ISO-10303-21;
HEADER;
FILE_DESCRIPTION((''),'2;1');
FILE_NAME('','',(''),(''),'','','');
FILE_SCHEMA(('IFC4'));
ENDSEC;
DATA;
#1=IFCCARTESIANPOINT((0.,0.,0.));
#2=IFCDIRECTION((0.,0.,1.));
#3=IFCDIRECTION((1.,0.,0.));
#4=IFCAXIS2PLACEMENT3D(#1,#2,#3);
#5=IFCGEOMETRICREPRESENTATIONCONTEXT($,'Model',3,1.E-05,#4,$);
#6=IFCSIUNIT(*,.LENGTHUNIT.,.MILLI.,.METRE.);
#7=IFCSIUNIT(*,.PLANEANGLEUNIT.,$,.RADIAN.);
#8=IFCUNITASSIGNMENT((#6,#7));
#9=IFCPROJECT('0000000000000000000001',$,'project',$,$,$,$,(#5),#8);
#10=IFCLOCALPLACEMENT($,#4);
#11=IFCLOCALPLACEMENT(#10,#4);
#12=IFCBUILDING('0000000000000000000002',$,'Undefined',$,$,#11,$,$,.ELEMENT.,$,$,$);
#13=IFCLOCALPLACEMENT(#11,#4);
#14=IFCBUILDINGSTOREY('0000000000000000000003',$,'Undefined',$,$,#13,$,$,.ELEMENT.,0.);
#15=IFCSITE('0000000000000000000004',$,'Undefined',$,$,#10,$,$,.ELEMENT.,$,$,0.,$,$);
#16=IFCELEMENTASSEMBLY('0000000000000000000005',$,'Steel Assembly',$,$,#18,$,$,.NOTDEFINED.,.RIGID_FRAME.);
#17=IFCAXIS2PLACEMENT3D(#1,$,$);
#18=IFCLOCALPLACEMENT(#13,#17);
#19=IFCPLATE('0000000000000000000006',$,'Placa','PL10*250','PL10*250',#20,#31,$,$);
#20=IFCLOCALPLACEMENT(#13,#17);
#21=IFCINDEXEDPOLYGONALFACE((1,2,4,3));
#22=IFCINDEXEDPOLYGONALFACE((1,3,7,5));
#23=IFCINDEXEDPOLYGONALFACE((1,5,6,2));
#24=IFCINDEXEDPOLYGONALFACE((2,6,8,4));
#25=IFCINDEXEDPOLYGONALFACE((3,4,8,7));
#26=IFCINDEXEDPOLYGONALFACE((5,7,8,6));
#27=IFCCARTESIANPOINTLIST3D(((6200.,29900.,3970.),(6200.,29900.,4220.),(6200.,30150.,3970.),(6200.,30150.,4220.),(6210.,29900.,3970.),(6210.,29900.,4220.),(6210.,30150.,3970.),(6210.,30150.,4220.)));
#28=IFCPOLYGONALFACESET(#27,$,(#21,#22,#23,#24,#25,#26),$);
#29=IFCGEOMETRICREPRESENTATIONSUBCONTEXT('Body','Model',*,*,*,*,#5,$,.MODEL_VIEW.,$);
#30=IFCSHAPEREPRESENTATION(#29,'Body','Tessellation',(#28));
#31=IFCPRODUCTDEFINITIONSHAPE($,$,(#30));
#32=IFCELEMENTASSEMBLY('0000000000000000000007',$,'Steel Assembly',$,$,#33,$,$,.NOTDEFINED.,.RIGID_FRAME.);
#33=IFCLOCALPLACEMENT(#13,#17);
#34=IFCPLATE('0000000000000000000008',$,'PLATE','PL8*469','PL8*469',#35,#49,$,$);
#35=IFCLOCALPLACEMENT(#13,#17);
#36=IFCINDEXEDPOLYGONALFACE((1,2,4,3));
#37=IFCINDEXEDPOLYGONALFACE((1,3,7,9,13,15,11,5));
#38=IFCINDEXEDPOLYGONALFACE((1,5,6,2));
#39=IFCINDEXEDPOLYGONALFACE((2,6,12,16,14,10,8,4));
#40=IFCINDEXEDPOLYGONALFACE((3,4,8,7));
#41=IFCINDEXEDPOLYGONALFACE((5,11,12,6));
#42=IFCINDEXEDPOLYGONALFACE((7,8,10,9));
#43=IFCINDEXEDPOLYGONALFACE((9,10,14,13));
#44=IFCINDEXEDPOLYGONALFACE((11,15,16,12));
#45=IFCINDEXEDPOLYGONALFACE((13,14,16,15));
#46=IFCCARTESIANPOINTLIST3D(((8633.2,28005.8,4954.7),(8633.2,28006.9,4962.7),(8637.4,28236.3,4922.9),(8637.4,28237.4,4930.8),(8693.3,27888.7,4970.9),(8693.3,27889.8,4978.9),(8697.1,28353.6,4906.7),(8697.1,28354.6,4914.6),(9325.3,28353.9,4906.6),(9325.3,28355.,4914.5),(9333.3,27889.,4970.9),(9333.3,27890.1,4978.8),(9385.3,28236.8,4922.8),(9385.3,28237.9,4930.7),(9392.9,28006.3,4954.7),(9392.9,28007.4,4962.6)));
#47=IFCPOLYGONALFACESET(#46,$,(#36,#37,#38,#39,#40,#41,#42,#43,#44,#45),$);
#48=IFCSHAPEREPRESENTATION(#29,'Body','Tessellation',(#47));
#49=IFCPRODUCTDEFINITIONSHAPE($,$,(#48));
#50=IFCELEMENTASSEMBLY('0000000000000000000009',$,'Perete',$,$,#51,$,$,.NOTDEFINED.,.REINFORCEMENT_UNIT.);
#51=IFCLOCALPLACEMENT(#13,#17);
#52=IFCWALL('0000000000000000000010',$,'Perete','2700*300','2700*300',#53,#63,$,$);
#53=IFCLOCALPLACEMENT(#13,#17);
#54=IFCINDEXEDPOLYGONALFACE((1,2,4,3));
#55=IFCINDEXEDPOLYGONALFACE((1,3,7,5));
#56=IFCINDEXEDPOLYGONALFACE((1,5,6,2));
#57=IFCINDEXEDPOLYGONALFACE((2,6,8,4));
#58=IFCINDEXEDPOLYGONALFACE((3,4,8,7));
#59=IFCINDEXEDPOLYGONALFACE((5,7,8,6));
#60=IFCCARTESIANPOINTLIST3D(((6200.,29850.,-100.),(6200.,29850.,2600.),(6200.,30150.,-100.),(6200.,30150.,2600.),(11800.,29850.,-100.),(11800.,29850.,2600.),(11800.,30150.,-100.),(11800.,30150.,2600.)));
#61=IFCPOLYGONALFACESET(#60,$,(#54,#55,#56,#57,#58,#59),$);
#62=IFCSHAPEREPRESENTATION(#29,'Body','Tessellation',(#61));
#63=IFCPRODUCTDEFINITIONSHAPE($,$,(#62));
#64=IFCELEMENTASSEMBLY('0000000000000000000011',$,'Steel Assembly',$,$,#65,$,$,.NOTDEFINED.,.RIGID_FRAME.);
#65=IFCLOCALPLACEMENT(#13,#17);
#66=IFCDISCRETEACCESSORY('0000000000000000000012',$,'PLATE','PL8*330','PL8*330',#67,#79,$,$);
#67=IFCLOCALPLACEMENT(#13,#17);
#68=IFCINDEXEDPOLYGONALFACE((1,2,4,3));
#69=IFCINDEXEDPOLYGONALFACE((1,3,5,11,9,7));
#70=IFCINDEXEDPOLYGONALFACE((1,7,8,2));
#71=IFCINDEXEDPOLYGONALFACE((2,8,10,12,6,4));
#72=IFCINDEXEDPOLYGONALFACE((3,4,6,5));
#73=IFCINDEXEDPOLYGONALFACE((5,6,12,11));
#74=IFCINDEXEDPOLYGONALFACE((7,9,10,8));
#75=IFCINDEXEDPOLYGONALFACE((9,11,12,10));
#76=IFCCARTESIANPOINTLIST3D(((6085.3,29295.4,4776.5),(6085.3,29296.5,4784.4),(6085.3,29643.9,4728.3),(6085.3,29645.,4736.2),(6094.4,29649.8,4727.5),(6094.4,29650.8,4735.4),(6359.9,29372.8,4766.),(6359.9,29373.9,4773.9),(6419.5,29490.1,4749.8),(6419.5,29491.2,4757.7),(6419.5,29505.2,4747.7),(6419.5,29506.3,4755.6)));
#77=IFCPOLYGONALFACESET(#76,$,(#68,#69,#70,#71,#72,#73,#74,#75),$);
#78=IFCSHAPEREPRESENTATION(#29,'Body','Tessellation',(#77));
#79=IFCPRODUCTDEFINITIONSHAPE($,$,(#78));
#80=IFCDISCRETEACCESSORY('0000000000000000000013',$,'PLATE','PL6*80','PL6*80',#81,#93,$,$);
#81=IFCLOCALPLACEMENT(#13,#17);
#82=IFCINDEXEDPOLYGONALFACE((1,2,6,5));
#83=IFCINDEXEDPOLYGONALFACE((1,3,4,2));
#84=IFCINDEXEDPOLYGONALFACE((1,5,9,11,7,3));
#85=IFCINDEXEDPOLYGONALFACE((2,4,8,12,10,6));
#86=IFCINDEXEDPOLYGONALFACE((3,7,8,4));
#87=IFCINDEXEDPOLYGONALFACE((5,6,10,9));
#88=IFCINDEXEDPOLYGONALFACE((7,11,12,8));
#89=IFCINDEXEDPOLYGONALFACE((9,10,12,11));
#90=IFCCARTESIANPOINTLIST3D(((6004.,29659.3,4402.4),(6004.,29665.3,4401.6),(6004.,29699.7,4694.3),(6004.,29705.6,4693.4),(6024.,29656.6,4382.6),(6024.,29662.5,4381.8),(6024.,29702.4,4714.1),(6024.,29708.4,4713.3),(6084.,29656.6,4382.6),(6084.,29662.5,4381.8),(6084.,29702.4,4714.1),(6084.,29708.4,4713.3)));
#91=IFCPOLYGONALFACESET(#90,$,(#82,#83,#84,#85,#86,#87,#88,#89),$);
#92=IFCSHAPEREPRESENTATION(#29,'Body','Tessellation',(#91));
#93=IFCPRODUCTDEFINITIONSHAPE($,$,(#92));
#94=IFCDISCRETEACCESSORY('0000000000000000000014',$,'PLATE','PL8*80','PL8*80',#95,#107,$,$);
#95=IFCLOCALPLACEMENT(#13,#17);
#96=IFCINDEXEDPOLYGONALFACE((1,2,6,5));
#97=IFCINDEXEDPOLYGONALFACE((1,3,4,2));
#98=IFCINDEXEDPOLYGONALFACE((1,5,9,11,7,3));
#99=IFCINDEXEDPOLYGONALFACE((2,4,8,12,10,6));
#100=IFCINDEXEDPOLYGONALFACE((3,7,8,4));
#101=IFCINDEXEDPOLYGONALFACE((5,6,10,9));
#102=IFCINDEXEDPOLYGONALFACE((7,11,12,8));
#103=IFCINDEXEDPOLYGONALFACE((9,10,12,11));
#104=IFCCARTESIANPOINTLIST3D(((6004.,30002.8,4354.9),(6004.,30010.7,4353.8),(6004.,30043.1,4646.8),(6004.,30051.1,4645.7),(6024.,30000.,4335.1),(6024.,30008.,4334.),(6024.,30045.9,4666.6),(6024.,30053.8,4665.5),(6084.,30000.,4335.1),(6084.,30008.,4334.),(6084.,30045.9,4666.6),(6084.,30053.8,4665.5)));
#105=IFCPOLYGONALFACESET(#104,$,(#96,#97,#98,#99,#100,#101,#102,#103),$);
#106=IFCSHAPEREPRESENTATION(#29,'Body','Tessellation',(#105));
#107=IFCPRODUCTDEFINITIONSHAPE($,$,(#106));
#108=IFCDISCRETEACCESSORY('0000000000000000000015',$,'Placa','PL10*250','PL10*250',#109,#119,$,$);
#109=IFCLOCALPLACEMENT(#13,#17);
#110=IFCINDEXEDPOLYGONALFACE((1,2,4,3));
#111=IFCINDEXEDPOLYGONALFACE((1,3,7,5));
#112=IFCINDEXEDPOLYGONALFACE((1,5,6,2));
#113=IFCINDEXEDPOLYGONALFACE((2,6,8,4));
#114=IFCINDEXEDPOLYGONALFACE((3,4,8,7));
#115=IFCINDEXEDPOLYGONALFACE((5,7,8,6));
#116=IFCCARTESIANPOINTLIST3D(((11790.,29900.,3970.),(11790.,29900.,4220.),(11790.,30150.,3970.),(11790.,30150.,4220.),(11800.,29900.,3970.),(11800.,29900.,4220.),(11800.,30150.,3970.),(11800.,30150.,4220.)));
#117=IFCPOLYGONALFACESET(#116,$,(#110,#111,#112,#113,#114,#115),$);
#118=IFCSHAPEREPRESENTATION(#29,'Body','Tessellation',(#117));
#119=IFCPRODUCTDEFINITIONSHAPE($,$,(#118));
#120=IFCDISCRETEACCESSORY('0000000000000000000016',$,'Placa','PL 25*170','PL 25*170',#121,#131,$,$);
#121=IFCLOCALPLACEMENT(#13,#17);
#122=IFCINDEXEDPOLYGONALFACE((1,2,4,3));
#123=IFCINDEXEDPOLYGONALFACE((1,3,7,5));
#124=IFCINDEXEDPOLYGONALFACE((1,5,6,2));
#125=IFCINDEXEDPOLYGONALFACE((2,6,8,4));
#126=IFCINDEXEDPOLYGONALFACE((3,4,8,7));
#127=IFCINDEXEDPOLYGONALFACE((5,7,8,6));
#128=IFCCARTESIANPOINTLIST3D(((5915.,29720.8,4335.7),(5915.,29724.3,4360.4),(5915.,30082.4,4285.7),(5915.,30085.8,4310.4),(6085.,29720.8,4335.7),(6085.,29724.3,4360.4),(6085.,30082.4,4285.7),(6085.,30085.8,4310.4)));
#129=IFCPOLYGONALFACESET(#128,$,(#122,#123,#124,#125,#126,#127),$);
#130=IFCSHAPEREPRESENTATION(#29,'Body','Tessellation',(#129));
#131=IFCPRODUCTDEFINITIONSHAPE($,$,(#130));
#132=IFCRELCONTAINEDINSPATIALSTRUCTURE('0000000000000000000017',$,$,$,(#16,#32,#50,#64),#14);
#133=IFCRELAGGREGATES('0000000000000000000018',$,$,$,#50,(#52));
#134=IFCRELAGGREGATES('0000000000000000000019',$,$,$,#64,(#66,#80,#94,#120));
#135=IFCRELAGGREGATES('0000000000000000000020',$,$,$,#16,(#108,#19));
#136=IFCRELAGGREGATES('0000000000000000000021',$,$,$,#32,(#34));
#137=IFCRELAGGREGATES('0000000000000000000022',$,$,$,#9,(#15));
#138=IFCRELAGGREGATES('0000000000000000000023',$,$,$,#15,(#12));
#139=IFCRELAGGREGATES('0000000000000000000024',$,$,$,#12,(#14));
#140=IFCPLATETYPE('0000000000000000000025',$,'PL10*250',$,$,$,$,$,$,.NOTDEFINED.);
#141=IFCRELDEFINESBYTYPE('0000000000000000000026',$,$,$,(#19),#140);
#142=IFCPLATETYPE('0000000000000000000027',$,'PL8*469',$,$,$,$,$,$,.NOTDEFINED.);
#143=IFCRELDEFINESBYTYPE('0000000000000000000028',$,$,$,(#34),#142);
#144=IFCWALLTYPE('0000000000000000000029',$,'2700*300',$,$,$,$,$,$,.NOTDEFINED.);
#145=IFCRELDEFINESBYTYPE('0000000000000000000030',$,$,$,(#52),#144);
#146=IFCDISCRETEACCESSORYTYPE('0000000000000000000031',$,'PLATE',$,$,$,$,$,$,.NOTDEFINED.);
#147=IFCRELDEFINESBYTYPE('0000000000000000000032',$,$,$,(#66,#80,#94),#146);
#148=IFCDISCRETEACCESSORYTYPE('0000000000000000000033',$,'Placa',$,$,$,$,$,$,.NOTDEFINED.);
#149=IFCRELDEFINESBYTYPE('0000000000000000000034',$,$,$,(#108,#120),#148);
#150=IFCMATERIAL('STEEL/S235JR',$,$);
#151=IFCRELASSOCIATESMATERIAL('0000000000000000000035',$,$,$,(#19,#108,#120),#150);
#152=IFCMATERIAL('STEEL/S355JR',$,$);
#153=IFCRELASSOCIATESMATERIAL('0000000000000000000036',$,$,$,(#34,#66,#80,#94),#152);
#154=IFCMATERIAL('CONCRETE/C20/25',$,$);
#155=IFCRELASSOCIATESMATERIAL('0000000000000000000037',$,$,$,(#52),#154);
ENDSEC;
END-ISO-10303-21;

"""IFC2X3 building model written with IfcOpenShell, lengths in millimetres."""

from ifc_helpers import new_model, si_unit, frame, frame_2d, origin_with_axes, place, context, subcontext, project, spatial, polyline, rectangle, outline, extrude, material, type_object, element, aggregate, save


model = new_model("IFC2X3")

# Units and contexts
model_context = context("Model", 3, precision=1e-05, world=origin_with_axes())
body_context = subcontext(model_context, "Body", "Model", "MODEL_VIEW")
ifc_project = project(units=[si_unit("LENGTHUNIT", "METRE", prefix="MILLI"), si_unit("PLANEANGLEUNIT", "RADIAN")], contexts=[model_context])

# Site, building, storey
site_placement = place(None, origin_with_axes())
site = spatial("IfcSite", under=ifc_project, at=site_placement, Name="Undefined", CompositionType="ELEMENT", RefElevation=0.0)
building_placement = place(site_placement, origin_with_axes())
building = spatial("IfcBuilding", under=site, at=building_placement, Name="Undefined", CompositionType="ELEMENT")
storey_placement = place(building_placement, origin_with_axes())
storey = spatial("IfcBuildingStorey", under=building, at=storey_placement, Name="Undefined", CompositionType="ELEMENT", Elevation=0.0)

# Shared definitions
ifc_material_1 = material(Name="STEEL/S355JR")

# Element assemblies, plates
assembly_1_placement = place(storey_placement, origin_with_axes())
assembly_1 = element("IfcElementAssembly", 1, at=assembly_1_placement, inside=storey, Name="Steel Assembly", AssemblyPlace="NOTDEFINED", PredefinedType="RIGID_FRAME")
ifc_material_2 = material(Name="STEEL/S235JR")
plate_type_1 = type_object("IfcPlateType", Name="PL10*250", PredefinedType="NOTDEFINED")
plate_1_placement = place(assembly_1_placement, frame((6205.0, 29900.0, 4220.0), z_axis=(1.0, 0.0, 0.0), x_axis=(0.0, 0.0, -1.0)))
plate_1 = element("IfcPlate", 2, at=plate_1_placement, type_object=plate_type_1, material=ifc_material_2, Name="Placa", Description="PL10*250", ObjectType="PL10*250", context=body_context, shape_type="SweptSolid", body=[
    extrude(outline(polyline([(0.0, 0.0), (250.0, 0.0), (250.0, 250.0), (0.0, 250.0), (0.0, 0.0)])), frame((0.0, 0.0, -5.0), z_axis=(0.0, 0.0, 1.0), x_axis=(1.0, 0.0, 0.0)), (0.0, 0.0, 1.0), 10.0),
])
assembly_2_placement = place(storey_placement, origin_with_axes())
assembly_2 = element("IfcElementAssembly", 3, at=assembly_2_placement, inside=storey, Name="Steel Assembly", AssemblyPlace="NOTDEFINED", PredefinedType="RIGID_FRAME")
plate_type_2 = type_object("IfcPlateType", Name="PL8*469", PredefinedType="NOTDEFINED")
plate_2_placement = place(assembly_2_placement, frame((9385.3, 28237.4, 4926.8), z_axis=(0.0, 0.136945, 0.990579), x_axis=(-0.452833, 0.883195, -0.1221)))
plate_2 = element("IfcPlate", 4, at=plate_2_placement, type_object=plate_type_2, material=ifc_material_1, Name="PLATE", Description="PL8*469", ObjectType="PL8*469", context=body_context, shape_type="SweptSolid", body=[
    extrude(outline(polyline([(0.0, 0.0), (132.6, 0.0), (416.7, 560.3), (338.2, 667.1), (132.6, 776.2), (0.0, 776.2), (-289.5, 205.4), (-210.9, 98.6), (0.0, 0.0)])), frame((0.0, 0.0, -4.0), z_axis=(0.0, 0.0, 1.0), x_axis=(1.0, 0.0, 0.0)), (0.0, 0.0, 1.0), 8.0),
])

# Element assembly, wall
assembly_3_placement = place(storey_placement, origin_with_axes())
assembly_3 = element("IfcElementAssembly", 5, at=assembly_3_placement, inside=storey, Name="Perete", AssemblyPlace="NOTDEFINED", PredefinedType="REINFORCEMENT_UNIT")
ifc_material_3 = material(Name="CONCRETE/C20/25")
wall_type = type_object("IfcWallType", Name="2700*300", PredefinedType="NOTDEFINED")
wall_placement = place(assembly_3_placement, frame((6200.0, 30000.0, -100.0), z_axis=(0.0, 0.0, 1.0), x_axis=(1.0, 0.0, 0.0)))
wall = element("IfcWall", 6, at=wall_placement, type_object=wall_type, material=ifc_material_3, Name="Perete", Description="2700*300", ObjectType="2700*300", context=body_context, shape_type="SweptSolid", body=[
    extrude(rectangle(XDim=5600.0, YDim=300.0, at=frame_2d((0.0, 2800.0), x_axis=(0.0, -1.0))), frame((0.0, 0.0, 0.0), z_axis=(0.0, 0.0, 1.0), x_axis=(0.0, -1.0, 0.0)), (0.0, 0.0, 1.0), 2700.0),
])
aggregate(assembly_3, [wall])

# Element assembly, discrete accessories
assembly_4_placement = place(storey_placement, origin_with_axes())
assembly_4 = element("IfcElementAssembly", 7, at=assembly_4_placement, inside=storey, Name="Steel Assembly", AssemblyPlace="NOTDEFINED", PredefinedType="RIGID_FRAME")
discrete_accessory_type_1 = type_object("IfcDiscreteAccessoryType", Name="PLATE")
discrete_accessory_1_placement = place(assembly_4_placement, frame((6085.3, 29295.9, 4780.5), z_axis=(0.000554, -0.13698, -0.990574), x_axis=(0.0, 0.990574, -0.13698)))
discrete_accessory_1 = element("IfcDiscreteAccessory", 8, at=discrete_accessory_1_placement, type_object=discrete_accessory_type_1, material=ifc_material_1, Name="PLATE", Description="PL8*330", ObjectType="PL8*330", context=body_context, shape_type="SweptSolid", body=[
    extrude(outline(polyline([(0.0, 0.0), (351.8, 0.0), (357.7, 9.1), (211.8, 334.2), (196.6, 334.2), (78.2, 274.6), (0.0, 0.0)])), frame((0.0, 0.0, -4.0), z_axis=(0.0, 0.0, 1.0), x_axis=(1.0, 0.0, 0.0)), (0.0, 0.0, 1.0), 8.0),
])
discrete_accessory_2_placement = place(assembly_4_placement, frame((6084.0, 29659.6, 4382.2), z_axis=(0.0, 0.990574, -0.13698), x_axis=(-1.0, 0.0, 0.0)))
discrete_accessory_2 = element("IfcDiscreteAccessory", 9, at=discrete_accessory_2_placement, type_object=discrete_accessory_type_1, material=ifc_material_1, Name="PLATE", Description="PL6*80", ObjectType="PL6*80", context=body_context, shape_type="SweptSolid", body=[
    extrude(outline(polyline([(0.0, 0.0), (60.0, 0.0), (80.0, 20.0), (80.0, 314.6), (60.0, 334.6), (0.0, 334.6), (0.0, 0.0)])), frame((0.0, 0.0, -3.0), z_axis=(0.0, 0.0, 1.0), x_axis=(1.0, 0.0, 0.0)), (0.0, 0.0, 1.0), 6.0),
])
discrete_accessory_3_placement = place(assembly_4_placement, frame((6084.0, 30004.0, 4334.6), z_axis=(0.0, 0.990574, -0.13698), x_axis=(-1.0, 0.0, 0.0)))
discrete_accessory_3 = element("IfcDiscreteAccessory", 10, at=discrete_accessory_3_placement, type_object=discrete_accessory_type_1, material=ifc_material_1, Name="PLATE", Description="PL8*80", ObjectType="PL8*80", context=body_context, shape_type="SweptSolid", body=[
    extrude(outline(polyline([(0.0, 0.0), (60.0, 0.0), (80.0, 20.0), (80.0, 314.6), (60.0, 334.6), (0.0, 334.6), (0.0, 0.0)])), frame((0.0, 0.0, -4.0), z_axis=(0.0, 0.0, 1.0), x_axis=(1.0, 0.0, 0.0)), (0.0, 0.0, 1.0), 8.0),
])

# Discrete accessories
discrete_accessory_type_2 = type_object("IfcDiscreteAccessoryType", Name="Placa")
discrete_accessory_4_placement = place(assembly_1_placement, frame((11795.0, 29900.0, 4220.0), z_axis=(1.0, 0.0, 0.0), x_axis=(0.0, 0.0, -1.0)))
discrete_accessory_4 = element("IfcDiscreteAccessory", 11, at=discrete_accessory_4_placement, type_object=discrete_accessory_type_2, material=ifc_material_2, Name="Placa", Description="PL10*250", ObjectType="PL10*250", context=body_context, shape_type="SweptSolid", body=[
    extrude(outline(polyline([(0.0, 0.0), (250.0, 0.0), (250.0, 250.0), (0.0, 250.0), (0.0, 0.0)])), frame((0.0, 0.0, -5.0), z_axis=(0.0, 0.0, 1.0), x_axis=(1.0, 0.0, 0.0)), (0.0, 0.0, 1.0), 10.0),
])
discrete_accessory_5_placement = place(assembly_4_placement, frame((6085.0, 30084.1, 4298.1), z_axis=(0.0, -0.13698, -0.990574), x_axis=(0.0, -0.990574, 0.13698)))
discrete_accessory_5 = element("IfcDiscreteAccessory", 12, at=discrete_accessory_5_placement, type_object=discrete_accessory_type_2, material=ifc_material_2, Name="Placa", Description="PL 25*170", ObjectType="PL 25*170", context=body_context, shape_type="SweptSolid", body=[
    extrude(outline(polyline([(0.0, 0.0), (365.0, 0.0), (365.0, 170.0), (0.0, 170.0), (0.0, 0.0)])), frame((0.0, 0.0, -12.5), z_axis=(0.0, 0.0, 1.0), x_axis=(1.0, 0.0, 0.0)), (0.0, 0.0, 1.0), 25.0),
])
aggregate(assembly_4, [discrete_accessory_1, discrete_accessory_2, discrete_accessory_3, discrete_accessory_5])

aggregate(assembly_1, [discrete_accessory_4, plate_1])
aggregate(assembly_2, [plate_2])

save(model, "model.ifc")
